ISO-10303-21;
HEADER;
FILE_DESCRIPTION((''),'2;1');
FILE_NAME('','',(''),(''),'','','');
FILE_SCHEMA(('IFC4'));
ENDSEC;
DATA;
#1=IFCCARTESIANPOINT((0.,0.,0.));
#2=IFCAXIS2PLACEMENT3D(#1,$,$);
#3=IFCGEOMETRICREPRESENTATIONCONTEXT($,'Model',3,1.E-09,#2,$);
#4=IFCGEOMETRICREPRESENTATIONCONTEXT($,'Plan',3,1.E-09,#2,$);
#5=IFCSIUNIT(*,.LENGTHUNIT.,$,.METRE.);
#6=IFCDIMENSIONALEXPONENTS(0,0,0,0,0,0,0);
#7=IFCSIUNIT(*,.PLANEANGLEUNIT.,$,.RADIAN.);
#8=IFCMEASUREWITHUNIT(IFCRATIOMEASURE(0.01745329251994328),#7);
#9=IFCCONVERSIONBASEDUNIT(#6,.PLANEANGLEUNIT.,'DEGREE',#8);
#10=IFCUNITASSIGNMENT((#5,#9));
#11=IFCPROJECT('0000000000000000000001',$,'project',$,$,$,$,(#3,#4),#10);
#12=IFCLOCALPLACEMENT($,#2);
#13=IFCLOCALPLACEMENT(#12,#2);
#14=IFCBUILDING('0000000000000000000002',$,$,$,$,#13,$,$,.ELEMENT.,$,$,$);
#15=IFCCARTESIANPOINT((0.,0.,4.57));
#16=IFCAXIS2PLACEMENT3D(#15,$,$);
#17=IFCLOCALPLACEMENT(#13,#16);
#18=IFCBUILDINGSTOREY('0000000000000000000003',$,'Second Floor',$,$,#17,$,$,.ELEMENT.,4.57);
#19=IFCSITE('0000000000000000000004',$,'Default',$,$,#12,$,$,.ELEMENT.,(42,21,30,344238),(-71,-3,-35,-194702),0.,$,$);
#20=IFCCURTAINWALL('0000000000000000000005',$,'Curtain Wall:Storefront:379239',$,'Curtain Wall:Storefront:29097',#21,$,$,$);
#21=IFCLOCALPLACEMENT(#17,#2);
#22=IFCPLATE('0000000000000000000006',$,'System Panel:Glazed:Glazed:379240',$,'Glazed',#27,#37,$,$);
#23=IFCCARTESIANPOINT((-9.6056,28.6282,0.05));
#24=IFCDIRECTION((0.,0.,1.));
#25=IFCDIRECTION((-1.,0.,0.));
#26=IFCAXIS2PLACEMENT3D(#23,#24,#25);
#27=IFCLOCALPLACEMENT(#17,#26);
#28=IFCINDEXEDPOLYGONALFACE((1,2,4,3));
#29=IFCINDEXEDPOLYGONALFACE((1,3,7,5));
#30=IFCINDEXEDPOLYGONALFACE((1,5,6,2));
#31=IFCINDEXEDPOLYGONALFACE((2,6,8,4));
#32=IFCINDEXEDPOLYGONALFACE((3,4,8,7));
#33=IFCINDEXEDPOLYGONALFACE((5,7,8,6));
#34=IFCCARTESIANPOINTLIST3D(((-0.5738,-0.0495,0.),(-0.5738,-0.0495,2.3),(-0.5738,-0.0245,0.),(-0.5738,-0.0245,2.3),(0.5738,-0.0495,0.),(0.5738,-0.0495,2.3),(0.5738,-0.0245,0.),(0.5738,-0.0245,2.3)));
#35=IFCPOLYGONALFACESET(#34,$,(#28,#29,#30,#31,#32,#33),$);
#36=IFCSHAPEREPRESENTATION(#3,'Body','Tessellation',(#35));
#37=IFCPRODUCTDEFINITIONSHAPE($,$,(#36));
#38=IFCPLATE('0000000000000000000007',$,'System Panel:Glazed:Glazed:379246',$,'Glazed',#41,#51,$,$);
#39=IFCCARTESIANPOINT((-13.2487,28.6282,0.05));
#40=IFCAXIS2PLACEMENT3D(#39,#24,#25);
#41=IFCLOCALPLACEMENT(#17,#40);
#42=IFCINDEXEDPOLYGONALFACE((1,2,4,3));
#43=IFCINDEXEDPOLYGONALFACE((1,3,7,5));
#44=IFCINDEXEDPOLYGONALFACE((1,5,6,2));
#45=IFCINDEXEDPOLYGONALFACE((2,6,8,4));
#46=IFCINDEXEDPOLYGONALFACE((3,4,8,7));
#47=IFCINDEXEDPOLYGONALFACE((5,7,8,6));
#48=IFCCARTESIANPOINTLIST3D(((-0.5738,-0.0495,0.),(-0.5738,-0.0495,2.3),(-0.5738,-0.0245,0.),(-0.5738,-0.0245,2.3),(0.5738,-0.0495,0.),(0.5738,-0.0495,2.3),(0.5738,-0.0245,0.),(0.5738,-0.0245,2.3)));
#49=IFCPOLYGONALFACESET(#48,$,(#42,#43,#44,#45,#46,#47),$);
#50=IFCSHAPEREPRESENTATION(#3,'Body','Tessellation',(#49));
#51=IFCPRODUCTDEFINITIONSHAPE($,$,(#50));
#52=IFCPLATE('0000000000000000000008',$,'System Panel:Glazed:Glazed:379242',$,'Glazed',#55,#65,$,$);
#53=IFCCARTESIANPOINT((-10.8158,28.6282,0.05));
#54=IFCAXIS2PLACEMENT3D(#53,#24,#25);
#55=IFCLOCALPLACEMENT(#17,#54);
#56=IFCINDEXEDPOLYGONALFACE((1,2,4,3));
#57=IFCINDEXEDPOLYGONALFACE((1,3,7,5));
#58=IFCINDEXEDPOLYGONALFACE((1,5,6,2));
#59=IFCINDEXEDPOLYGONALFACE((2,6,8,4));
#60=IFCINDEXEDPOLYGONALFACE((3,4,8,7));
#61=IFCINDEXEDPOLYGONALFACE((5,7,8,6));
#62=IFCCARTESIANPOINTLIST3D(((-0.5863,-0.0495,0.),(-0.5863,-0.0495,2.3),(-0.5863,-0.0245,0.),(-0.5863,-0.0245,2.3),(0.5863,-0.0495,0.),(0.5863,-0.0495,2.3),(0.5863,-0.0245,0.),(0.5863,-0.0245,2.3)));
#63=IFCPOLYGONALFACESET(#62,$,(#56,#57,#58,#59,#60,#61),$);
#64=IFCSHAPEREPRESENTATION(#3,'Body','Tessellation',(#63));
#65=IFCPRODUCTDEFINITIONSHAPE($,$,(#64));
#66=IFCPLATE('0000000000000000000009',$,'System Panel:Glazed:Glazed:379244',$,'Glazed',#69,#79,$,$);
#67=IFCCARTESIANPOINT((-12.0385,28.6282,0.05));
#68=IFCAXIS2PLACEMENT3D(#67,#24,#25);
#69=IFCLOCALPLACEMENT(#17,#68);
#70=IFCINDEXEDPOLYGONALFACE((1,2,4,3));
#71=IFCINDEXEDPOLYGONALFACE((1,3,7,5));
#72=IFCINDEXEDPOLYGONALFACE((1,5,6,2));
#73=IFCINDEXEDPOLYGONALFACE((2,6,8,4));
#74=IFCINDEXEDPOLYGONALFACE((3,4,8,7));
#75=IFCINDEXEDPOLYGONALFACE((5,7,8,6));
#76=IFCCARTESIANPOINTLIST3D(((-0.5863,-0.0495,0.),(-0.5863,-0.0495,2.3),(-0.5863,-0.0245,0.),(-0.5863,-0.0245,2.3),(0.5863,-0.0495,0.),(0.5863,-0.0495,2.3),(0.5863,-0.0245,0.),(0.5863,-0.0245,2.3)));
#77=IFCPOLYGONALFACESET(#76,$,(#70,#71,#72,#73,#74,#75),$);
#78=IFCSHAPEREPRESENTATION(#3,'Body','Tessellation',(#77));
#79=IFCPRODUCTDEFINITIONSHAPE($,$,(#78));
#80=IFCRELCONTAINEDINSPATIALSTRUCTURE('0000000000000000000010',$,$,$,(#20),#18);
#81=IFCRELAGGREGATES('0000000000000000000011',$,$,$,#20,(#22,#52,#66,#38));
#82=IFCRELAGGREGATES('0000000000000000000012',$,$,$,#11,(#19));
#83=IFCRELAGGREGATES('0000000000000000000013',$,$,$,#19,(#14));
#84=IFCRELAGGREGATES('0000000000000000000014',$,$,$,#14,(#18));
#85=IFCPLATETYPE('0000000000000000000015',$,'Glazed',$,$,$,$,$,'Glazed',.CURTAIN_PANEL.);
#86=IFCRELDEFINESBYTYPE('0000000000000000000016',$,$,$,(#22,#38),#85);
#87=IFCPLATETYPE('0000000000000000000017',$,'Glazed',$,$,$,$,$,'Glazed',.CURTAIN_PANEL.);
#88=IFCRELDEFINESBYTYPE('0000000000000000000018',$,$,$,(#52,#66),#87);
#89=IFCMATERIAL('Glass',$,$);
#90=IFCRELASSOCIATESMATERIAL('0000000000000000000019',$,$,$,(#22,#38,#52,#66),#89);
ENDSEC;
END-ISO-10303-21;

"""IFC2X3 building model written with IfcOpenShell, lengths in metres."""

from ifc_helpers import new_model, entity, si_unit, converted_unit, frame, origin, origin_2d_with_axis, place, context, project, spatial, rectangle, extrude, source, transform, mapped, material, type_object, type_shapes, element, aggregate, save


model = new_model("IFC2X3")

# Units and contexts
model_context = context("Model", 3, precision=1e-09, world=origin())
plan_context = context("Plan", 3, precision=1e-09, world=origin())
ifc_project = project(units=[si_unit("LENGTHUNIT", "METRE"), converted_unit("PLANEANGLEUNIT", "DEGREE", entity("IfcRatioMeasure", 0.01745329251994328), si_unit("PLANEANGLEUNIT", "RADIAN"), dimensions=[0, 0, 0, 0, 0, 0, 0])], contexts=[model_context, plan_context])

# Site, building, storey
site_placement = place(None, origin())
site = spatial("IfcSite", under=ifc_project, at=site_placement, Name="Default", CompositionType="ELEMENT", RefLatitude=(42, 21, 30, 344238), RefLongitude=(-71, -3, -35, -194702), RefElevation=0.0)
building_placement = place(site_placement, origin())
building = spatial("IfcBuilding", under=site, at=building_placement, CompositionType="ELEMENT")
storey_placement = place(building_placement, frame((0.0, 0.0, 4.57)))
storey = spatial("IfcBuildingStorey", under=building, at=storey_placement, Name="Second Floor", CompositionType="ELEMENT", Elevation=4.57)

# Curtain wall, plates
curtain_wall_placement = place(storey_placement, origin())
curtain_wall = element("IfcCurtainWall", 1, at=curtain_wall_placement, inside=storey, Name="Curtain Wall:Storefront:379239", ObjectType="Curtain Wall:Storefront:29097")
ifc_material_1 = material(Name="Glass")
plate_type_1 = type_object("IfcPlateType", Name="Glazed", ElementType="Glazed", PredefinedType="CURTAIN_PANEL")
shared_shape_1 = source(origin(), model_context, "Body", "SweptSolid", [
    extrude(rectangle(XDim=0.025, YDim=1.1477, at=origin_2d_with_axis()), frame((0.0, -0.037, 0.0), z_axis=(0.0, 0.0, 1.0), x_axis=(0.0, 1.0, 0.0)), (0.0, 0.0, 1.0), 2.3),
])
type_shapes(plate_type_1, [shared_shape_1])
plate_1_placement = place(storey_placement, frame((-9.6056, 28.6282, 0.05), z_axis=(0.0, 0.0, 1.0), x_axis=(-1.0, 0.0, 0.0)))
plate_1 = element("IfcPlate", 2, at=plate_1_placement, type_object=plate_type_1, material=ifc_material_1, Name="System Panel:Glazed:Glazed:379240", ObjectType="Glazed", context=model_context, shape_type="MappedRepresentation", body=[
    mapped(shared_shape_1, transform((0.0, 0.0, 0.0), scale=1.0)),
])
plate_2_placement = place(storey_placement, frame((-13.2487, 28.6282, 0.05), z_axis=(0.0, 0.0, 1.0), x_axis=(-1.0, 0.0, 0.0)))
plate_2 = element("IfcPlate", 3, at=plate_2_placement, type_object=plate_type_1, material=ifc_material_1, Name="System Panel:Glazed:Glazed:379246", ObjectType="Glazed", context=model_context, shape_type="MappedRepresentation", body=[
    mapped(shared_shape_1, transform((0.0, 0.0, 0.0), scale=1.0)),
])
plate_type_2 = type_object("IfcPlateType", Name="Glazed", ElementType="Glazed", PredefinedType="CURTAIN_PANEL")
shared_shape_2 = source(origin(), model_context, "Body", "SweptSolid", [
    extrude(rectangle(XDim=0.025, YDim=1.1727, at=origin_2d_with_axis()), frame((0.0, -0.037, 0.0), z_axis=(0.0, 0.0, 1.0), x_axis=(0.0, 1.0, 0.0)), (0.0, 0.0, 1.0), 2.3),
])
type_shapes(plate_type_2, [shared_shape_2])
plate_3_placement = place(storey_placement, frame((-10.8158, 28.6282, 0.05), z_axis=(0.0, 0.0, 1.0), x_axis=(-1.0, 0.0, 0.0)))
plate_3 = element("IfcPlate", 4, at=plate_3_placement, type_object=plate_type_2, material=ifc_material_1, Name="System Panel:Glazed:Glazed:379242", ObjectType="Glazed", context=model_context, shape_type="MappedRepresentation", body=[
    mapped(shared_shape_2, transform((0.0, 0.0, 0.0), scale=1.0)),
])
plate_4_placement = place(storey_placement, frame((-12.0385, 28.6282, 0.05), z_axis=(0.0, 0.0, 1.0), x_axis=(-1.0, 0.0, 0.0)))
plate_4 = element("IfcPlate", 5, at=plate_4_placement, type_object=plate_type_2, material=ifc_material_1, Name="System Panel:Glazed:Glazed:379244", ObjectType="Glazed", context=model_context, shape_type="MappedRepresentation", body=[
    mapped(shared_shape_2, transform((0.0, 0.0, 0.0), scale=1.0)),
])
aggregate(curtain_wall, [plate_1, plate_3, plate_4, plate_2])

save(model, "model.ifc")
